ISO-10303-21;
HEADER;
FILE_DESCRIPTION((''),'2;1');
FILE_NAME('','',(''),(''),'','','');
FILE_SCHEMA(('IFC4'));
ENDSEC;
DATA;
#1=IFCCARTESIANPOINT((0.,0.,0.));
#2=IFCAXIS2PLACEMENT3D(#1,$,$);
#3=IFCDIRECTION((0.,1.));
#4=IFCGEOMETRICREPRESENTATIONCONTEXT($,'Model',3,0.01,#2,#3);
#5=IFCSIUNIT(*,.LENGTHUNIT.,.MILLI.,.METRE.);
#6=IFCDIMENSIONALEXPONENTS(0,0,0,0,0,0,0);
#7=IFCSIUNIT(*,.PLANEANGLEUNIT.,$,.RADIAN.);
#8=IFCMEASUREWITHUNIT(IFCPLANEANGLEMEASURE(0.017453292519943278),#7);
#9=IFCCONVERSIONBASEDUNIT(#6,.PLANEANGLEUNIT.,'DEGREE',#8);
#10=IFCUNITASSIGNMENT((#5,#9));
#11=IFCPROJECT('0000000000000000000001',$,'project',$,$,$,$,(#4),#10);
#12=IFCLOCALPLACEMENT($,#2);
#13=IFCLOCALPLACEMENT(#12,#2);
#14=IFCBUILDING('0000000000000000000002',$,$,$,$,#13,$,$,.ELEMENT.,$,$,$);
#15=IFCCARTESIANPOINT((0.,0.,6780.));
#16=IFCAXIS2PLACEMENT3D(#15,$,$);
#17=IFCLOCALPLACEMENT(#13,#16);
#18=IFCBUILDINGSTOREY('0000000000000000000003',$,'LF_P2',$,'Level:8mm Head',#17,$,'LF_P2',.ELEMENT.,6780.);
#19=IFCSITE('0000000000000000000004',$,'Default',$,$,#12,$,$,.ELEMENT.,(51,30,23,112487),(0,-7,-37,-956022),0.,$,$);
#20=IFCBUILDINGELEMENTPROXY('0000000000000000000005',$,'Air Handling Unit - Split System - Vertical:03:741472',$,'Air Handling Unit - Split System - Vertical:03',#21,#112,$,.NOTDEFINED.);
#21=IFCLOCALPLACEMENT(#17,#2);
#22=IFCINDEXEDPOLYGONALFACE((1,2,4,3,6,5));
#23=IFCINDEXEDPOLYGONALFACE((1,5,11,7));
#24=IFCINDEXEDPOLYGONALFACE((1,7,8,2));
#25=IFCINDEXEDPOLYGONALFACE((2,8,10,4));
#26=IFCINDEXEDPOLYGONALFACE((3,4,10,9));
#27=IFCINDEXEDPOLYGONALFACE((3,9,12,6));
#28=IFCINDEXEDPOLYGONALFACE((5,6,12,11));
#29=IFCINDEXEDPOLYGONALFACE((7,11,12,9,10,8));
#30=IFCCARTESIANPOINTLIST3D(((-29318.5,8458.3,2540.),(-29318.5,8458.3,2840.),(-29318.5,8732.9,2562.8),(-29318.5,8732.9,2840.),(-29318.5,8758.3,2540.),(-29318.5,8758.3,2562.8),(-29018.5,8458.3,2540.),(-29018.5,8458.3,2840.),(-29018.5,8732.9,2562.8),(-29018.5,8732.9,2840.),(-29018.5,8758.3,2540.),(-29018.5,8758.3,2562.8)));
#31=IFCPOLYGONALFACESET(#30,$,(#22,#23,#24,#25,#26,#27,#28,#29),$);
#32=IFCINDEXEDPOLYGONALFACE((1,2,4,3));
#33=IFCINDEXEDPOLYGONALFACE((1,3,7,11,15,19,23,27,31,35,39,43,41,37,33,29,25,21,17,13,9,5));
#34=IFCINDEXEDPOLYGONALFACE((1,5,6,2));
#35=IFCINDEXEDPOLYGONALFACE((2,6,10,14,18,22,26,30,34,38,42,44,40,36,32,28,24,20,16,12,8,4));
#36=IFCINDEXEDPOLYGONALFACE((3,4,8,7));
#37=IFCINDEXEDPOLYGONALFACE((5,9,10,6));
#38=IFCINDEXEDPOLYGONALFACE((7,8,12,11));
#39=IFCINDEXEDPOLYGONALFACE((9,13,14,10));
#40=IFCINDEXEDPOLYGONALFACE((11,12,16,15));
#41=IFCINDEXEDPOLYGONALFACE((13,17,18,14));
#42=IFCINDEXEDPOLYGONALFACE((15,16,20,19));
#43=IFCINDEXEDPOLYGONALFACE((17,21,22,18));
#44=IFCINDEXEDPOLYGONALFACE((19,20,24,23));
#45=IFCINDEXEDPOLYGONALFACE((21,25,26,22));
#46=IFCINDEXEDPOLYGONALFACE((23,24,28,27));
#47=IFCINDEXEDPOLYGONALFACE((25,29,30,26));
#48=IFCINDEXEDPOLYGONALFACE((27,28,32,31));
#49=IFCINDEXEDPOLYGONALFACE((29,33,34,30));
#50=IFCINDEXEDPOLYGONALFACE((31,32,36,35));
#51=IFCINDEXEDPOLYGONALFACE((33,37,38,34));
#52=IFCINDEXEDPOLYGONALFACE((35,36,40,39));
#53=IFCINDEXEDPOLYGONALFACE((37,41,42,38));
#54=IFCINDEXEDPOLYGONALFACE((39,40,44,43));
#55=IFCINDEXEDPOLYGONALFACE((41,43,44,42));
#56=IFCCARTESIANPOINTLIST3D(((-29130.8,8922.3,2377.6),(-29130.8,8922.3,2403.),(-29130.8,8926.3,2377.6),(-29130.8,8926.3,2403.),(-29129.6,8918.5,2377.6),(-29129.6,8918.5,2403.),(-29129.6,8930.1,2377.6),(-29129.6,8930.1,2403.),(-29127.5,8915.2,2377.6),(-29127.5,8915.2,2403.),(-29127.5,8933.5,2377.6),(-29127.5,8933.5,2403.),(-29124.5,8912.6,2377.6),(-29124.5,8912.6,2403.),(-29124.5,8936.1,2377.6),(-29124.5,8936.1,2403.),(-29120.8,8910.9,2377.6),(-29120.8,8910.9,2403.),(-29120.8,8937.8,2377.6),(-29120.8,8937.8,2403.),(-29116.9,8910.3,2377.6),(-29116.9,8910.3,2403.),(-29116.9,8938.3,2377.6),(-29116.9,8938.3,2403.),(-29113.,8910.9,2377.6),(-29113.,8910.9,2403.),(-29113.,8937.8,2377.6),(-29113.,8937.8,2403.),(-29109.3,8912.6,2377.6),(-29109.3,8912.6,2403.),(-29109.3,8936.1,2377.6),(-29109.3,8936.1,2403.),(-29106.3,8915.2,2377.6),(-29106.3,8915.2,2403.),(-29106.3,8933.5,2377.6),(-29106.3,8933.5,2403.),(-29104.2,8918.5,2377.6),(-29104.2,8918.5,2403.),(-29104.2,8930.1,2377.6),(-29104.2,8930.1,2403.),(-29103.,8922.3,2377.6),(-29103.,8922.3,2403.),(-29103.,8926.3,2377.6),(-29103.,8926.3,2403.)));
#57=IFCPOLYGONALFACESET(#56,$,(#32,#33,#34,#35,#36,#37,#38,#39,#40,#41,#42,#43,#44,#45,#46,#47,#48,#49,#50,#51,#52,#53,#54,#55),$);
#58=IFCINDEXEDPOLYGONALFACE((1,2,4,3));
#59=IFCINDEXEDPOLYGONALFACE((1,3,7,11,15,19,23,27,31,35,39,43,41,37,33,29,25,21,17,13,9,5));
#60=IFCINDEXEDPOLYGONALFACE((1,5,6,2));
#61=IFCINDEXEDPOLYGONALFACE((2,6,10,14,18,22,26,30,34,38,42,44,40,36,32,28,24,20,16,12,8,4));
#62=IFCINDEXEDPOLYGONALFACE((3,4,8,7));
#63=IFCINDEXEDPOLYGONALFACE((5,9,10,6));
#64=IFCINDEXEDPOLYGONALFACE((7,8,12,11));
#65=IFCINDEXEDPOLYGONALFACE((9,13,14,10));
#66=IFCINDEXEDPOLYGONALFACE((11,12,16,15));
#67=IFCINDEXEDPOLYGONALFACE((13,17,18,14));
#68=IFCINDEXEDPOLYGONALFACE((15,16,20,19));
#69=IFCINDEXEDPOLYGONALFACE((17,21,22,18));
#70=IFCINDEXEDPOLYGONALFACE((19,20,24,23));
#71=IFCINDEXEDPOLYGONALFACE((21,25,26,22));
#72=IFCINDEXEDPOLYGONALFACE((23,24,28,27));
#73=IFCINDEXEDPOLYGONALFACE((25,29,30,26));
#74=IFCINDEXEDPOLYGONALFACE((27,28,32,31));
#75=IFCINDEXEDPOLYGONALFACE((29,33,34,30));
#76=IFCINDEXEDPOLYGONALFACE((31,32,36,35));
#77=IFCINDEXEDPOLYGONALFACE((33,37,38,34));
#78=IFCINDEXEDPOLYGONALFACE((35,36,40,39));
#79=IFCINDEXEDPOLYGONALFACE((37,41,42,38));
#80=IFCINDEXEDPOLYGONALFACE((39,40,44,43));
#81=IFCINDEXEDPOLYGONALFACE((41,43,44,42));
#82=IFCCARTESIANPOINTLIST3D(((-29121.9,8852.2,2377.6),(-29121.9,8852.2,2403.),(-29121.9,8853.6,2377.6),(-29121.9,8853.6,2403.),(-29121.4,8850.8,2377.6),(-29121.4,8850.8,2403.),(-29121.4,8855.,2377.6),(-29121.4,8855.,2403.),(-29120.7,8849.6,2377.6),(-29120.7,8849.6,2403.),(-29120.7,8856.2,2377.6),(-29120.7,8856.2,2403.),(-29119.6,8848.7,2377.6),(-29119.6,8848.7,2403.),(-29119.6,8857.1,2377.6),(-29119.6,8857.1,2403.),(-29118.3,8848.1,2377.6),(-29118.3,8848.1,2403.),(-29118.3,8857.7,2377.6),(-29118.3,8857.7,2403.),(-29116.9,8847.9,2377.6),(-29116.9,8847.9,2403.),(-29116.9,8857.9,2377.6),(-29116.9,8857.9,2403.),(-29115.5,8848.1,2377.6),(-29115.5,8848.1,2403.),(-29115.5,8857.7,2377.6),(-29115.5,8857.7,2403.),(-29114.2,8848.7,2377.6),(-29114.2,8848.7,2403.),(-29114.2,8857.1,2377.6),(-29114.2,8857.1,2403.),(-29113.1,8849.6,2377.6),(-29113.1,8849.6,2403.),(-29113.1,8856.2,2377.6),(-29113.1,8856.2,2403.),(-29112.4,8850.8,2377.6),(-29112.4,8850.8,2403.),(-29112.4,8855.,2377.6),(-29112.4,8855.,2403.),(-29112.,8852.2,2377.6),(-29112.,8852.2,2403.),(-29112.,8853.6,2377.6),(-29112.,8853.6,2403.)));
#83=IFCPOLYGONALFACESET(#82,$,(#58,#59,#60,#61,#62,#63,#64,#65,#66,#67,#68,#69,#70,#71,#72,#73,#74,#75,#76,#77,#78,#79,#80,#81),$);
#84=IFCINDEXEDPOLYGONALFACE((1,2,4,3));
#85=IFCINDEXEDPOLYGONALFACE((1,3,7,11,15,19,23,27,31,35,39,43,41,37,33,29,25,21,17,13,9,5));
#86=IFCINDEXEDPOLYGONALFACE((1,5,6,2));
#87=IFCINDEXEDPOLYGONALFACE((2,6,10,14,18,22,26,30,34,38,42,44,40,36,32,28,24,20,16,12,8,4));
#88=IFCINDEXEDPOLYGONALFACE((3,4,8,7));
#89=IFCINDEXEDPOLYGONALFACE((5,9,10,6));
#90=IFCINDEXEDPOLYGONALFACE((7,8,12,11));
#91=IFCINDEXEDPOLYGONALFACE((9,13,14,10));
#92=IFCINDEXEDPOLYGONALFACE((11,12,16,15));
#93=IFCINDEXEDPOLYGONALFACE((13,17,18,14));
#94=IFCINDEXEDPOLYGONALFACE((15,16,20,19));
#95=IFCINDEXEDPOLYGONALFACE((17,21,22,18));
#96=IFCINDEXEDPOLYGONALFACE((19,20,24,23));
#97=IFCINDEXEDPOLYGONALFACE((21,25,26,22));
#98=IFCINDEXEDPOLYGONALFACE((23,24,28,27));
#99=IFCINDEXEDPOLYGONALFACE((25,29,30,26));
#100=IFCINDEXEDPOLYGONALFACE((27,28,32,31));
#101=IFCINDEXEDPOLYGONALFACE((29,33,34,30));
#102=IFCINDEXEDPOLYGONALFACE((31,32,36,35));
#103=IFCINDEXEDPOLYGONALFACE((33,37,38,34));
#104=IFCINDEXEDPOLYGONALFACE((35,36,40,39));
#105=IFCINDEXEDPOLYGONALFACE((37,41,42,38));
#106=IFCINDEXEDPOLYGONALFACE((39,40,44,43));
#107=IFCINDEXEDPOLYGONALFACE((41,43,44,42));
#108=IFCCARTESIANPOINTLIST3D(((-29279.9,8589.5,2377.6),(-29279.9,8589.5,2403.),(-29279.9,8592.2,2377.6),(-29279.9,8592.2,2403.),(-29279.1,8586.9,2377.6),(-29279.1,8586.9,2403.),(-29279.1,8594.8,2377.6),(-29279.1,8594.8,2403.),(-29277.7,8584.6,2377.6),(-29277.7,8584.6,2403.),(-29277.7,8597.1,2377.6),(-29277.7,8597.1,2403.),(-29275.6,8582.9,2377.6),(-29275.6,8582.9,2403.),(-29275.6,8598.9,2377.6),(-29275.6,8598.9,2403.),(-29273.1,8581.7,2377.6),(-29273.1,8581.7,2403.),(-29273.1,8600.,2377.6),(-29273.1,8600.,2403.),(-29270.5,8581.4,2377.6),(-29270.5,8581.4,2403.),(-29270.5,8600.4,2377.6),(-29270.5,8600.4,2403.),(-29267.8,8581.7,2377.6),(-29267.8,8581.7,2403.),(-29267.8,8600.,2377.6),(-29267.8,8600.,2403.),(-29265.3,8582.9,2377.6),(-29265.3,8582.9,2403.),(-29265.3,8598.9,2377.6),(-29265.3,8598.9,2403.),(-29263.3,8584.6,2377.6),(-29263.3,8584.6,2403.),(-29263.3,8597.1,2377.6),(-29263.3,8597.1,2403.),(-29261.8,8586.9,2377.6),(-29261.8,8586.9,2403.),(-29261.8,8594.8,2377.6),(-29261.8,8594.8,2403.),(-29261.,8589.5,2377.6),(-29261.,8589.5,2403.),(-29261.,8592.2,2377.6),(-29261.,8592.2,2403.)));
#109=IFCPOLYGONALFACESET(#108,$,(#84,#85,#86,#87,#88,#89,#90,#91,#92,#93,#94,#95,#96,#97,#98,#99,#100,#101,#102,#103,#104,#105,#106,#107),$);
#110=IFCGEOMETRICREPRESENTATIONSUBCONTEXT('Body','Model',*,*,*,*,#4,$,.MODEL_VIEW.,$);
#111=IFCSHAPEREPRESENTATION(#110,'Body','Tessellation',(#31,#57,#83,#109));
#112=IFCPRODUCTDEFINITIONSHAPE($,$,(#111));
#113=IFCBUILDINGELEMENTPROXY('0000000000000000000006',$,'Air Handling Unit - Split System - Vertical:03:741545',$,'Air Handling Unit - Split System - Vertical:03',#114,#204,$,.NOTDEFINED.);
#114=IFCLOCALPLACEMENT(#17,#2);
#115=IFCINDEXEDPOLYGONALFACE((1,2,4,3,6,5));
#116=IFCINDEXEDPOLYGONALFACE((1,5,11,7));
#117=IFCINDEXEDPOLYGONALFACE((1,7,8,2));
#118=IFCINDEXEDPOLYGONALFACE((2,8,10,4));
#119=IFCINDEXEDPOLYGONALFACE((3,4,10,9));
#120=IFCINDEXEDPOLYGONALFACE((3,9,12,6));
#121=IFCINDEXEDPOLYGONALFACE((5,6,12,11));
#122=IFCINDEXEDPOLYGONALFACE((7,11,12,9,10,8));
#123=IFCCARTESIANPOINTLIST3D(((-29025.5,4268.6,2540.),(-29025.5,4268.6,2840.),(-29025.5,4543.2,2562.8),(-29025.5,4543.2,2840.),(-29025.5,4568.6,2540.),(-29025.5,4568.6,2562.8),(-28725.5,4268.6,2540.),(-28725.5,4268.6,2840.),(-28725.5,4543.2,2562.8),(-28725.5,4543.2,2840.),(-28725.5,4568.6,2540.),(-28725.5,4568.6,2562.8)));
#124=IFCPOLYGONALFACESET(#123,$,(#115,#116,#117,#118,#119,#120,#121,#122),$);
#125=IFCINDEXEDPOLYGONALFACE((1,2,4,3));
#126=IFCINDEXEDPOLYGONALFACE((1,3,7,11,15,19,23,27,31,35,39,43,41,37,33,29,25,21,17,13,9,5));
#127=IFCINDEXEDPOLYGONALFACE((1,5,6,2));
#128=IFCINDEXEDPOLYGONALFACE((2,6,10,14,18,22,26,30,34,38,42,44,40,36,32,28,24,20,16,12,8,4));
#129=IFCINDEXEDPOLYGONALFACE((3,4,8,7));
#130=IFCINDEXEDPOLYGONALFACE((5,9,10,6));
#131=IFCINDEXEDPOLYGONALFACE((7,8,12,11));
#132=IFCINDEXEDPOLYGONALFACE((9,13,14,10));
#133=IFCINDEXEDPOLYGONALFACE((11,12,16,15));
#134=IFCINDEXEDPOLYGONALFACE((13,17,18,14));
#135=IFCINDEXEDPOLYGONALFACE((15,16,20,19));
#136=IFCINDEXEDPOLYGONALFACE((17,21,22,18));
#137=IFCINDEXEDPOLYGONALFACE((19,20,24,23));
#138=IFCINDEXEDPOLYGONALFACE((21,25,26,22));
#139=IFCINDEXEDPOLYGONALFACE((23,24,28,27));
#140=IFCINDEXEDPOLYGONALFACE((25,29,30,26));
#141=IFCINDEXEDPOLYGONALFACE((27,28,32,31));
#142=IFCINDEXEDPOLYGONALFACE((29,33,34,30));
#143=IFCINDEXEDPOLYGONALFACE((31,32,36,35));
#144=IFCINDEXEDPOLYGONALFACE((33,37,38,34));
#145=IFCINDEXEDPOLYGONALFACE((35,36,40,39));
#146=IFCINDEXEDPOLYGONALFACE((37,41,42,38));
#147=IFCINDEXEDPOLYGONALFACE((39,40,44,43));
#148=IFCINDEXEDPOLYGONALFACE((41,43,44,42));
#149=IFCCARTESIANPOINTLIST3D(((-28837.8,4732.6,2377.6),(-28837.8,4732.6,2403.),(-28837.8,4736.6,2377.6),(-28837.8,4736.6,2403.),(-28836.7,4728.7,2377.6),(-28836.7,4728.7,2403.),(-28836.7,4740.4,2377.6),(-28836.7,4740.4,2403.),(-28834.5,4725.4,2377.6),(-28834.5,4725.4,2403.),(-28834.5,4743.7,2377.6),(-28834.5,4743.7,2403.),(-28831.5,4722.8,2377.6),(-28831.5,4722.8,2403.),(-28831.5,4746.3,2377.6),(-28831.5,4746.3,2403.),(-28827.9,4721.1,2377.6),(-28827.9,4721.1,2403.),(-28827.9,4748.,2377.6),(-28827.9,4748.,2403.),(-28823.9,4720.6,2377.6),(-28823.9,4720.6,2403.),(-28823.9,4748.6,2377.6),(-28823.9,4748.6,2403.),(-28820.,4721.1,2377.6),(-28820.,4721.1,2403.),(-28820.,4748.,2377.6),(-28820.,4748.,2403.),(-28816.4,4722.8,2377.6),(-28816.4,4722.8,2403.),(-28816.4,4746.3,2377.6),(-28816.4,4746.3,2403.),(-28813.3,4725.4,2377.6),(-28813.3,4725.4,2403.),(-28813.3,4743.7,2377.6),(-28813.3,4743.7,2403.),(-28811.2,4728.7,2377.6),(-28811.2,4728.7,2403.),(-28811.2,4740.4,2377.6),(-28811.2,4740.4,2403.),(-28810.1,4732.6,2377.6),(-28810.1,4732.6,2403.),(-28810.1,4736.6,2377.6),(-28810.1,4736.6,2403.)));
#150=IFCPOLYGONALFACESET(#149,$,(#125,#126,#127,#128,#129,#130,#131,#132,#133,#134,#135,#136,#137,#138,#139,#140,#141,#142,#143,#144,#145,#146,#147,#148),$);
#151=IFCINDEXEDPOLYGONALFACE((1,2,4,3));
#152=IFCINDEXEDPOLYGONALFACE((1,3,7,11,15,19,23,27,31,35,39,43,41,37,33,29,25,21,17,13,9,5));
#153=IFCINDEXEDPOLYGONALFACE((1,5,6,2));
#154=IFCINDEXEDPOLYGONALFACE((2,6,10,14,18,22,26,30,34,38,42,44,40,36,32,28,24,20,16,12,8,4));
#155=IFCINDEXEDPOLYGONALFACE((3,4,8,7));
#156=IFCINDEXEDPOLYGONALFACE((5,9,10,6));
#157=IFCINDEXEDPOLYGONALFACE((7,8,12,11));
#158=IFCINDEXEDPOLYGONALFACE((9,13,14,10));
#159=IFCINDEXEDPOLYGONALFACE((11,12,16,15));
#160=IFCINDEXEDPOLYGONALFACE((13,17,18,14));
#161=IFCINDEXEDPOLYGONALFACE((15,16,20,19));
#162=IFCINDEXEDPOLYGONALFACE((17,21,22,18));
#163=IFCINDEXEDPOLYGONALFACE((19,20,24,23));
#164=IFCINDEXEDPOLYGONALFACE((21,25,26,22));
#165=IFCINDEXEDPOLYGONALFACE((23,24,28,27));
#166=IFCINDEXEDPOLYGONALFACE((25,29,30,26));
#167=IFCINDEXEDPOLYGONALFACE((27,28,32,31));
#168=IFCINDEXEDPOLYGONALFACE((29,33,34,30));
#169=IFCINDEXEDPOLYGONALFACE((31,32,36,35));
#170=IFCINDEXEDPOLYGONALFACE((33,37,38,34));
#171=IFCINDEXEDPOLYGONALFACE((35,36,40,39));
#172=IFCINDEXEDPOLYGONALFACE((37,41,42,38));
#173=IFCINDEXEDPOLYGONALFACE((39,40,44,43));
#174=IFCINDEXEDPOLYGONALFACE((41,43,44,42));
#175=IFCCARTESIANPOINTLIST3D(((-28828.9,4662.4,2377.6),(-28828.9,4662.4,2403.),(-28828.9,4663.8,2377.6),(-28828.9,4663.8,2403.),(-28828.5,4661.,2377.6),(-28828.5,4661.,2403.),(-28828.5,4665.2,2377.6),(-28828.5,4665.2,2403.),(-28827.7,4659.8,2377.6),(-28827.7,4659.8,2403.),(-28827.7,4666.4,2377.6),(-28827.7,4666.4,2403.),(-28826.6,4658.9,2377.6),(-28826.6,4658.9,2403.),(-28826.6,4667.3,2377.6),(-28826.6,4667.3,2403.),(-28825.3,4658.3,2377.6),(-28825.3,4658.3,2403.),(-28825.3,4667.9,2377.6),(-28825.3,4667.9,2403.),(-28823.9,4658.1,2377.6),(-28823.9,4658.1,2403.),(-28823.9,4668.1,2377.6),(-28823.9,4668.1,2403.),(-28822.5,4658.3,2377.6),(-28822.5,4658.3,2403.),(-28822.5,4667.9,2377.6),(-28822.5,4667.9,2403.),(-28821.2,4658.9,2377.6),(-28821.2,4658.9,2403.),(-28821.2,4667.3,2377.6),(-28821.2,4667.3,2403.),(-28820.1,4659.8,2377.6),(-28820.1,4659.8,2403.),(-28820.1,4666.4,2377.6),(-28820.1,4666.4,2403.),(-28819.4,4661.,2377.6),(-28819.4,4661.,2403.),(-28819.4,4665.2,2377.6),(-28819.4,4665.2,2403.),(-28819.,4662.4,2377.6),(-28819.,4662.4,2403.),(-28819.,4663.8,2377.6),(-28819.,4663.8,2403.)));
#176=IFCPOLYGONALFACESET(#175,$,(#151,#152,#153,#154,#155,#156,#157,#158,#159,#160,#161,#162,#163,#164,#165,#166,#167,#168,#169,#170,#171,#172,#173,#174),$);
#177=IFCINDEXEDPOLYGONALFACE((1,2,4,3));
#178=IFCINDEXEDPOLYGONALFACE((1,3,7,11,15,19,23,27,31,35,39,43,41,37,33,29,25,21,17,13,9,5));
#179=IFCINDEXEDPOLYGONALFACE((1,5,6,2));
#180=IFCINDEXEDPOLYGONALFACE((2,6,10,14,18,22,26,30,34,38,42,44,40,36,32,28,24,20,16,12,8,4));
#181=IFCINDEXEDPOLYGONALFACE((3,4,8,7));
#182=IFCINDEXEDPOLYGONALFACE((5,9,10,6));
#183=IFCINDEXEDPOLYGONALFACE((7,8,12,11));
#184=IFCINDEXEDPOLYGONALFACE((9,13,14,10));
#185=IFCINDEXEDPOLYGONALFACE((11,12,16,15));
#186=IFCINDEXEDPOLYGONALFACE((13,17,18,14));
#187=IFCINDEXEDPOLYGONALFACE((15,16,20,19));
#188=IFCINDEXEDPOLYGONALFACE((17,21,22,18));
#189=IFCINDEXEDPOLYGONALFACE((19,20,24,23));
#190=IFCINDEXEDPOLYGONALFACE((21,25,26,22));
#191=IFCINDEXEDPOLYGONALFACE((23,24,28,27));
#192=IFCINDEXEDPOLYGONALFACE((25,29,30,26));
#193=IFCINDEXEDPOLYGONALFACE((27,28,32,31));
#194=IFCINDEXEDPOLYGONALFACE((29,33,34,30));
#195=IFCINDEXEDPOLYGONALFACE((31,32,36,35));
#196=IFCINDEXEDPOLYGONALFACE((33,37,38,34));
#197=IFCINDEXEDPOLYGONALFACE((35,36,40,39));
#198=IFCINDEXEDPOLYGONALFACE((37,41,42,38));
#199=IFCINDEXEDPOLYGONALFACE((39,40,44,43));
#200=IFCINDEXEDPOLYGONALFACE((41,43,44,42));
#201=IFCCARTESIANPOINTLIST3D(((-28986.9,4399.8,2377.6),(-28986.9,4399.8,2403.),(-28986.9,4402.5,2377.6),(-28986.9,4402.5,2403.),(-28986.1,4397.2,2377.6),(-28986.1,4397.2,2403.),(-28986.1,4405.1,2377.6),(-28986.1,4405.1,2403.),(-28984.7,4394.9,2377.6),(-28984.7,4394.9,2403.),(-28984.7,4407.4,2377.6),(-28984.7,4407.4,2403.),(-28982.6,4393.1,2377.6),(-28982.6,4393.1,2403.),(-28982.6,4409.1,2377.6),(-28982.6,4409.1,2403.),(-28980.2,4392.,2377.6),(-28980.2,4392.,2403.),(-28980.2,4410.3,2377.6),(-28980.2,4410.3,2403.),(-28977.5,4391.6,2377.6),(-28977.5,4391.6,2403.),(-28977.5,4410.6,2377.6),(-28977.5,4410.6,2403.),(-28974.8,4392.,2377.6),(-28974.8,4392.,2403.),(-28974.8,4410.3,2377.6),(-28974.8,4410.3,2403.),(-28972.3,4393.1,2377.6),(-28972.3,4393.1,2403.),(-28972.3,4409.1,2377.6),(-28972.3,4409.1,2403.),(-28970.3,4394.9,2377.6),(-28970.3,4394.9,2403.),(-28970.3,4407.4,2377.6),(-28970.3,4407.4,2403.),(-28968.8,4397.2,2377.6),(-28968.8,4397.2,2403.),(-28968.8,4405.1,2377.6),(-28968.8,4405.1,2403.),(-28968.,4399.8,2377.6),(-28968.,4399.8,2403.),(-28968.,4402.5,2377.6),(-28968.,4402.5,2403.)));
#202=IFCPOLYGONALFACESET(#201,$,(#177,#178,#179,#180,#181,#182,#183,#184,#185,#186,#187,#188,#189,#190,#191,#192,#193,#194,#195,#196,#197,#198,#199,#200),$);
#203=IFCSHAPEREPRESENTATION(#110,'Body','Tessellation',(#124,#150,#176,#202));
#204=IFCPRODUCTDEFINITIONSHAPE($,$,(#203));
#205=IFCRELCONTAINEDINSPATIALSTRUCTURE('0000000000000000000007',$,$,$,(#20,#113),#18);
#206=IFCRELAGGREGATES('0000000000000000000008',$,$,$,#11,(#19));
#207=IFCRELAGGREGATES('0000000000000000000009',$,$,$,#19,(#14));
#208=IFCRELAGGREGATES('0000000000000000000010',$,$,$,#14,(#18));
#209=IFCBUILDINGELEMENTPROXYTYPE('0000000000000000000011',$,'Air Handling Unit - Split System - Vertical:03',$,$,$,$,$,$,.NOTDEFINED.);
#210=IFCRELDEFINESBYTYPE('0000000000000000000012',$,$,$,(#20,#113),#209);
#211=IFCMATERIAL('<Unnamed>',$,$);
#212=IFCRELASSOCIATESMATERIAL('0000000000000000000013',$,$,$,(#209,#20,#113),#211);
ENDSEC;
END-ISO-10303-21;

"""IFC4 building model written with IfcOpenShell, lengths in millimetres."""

from ifc_helpers import new_model, entity, si_unit, converted_unit, direction, frame, origin, place, context, subcontext, project, spatial, arc, indexed_curve, outline, extrude, source, transform, mapped, material, type_object, type_shapes, element, save


model = new_model("IFC4")

# Units and contexts
model_context = context("Model", 3, precision=0.01, world=origin(), true_north=direction((0.0, 1.0)))
body_context = subcontext(model_context, "Body", "Model", "MODEL_VIEW")
ifc_project = project(units=[si_unit("LENGTHUNIT", "METRE", prefix="MILLI"), converted_unit("PLANEANGLEUNIT", "DEGREE", entity("IfcPlaneAngleMeasure", 0.017453292519943278), si_unit("PLANEANGLEUNIT", "RADIAN"), dimensions=[0, 0, 0, 0, 0, 0, 0])], contexts=[model_context])

# Site, building, storey
site_placement = place(None, origin())
site = spatial("IfcSite", under=ifc_project, at=site_placement, Name="Default", CompositionType="ELEMENT", RefLatitude=(51, 30, 23, 112487), RefLongitude=(0, -7, -37, -956022), RefElevation=0.0)
building_placement = place(site_placement, origin())
building = spatial("IfcBuilding", under=site, at=building_placement, CompositionType="ELEMENT")
storey_placement = place(building_placement, frame((0.0, 0.0, 6780.0)))
storey = spatial("IfcBuildingStorey", under=building, at=storey_placement, Name="LF_P2", ObjectType="Level:8mm Head", LongName="LF_P2", CompositionType="ELEMENT", Elevation=6780.0)

# Shared definitions
ifc_material = material(Name="<Unnamed>")

# Building element proxies
building_element_proxy_type_1 = type_object("IfcBuildingElementProxyType", Name="Air Handling Unit - Split System - Vertical:03", PredefinedType="NOTDEFINED", material=ifc_material)
shared_shape_1 = source(origin(), body_context, "Body", "SweptSolid", [
    extrude(outline(indexed_curve([(-191.5, -107.6), (108.5, -107.6), (108.5, -84.8), (83.1, -84.8), (83.1, 192.4), (-191.5, 192.4), (-191.5, -107.6)], self_intersect=False)), frame((-150.0, 42.4, 191.5), z_axis=(1.0, 0.0, 0.0), x_axis=(0.0, 0.0, 1.0)), (0.0, 0.0, 1.0), 300.0),
    extrude(outline(indexed_curve([(-14.0, 0.0), (0.0, -14.0), (14.0, 0.0), (0.0, 14.0)], segments=[arc(1, 2, 3), arc(3, 4, 1)], self_intersect=False)), frame((51.6, 287.0, 466.0), z_axis=(0.0, 1.0, 0.0), x_axis=(0.0, 0.0, -1.0)), (0.0, 0.0, 1.0), 25.4),
    extrude(outline(indexed_curve([(-5.0, 0.0), (0.0, -5.0), (5.0, 0.0), (0.0, 5.0)], segments=[arc(1, 2, 3), arc(3, 4, 1)], self_intersect=False)), frame((51.6, 287.0, 394.6), z_axis=(0.0, 1.0, 0.0), x_axis=(0.0, 0.0, -1.0)), (0.0, 0.0, 1.0), 25.4),
    extrude(outline(indexed_curve([(-9.5, 0.0), (0.0, -9.5), (9.5, 0.0), (0.0, 9.5)], segments=[arc(1, 2, 3), arc(3, 4, 1)], self_intersect=False)), frame((-102.0, 287.0, 132.6), z_axis=(0.0, 1.0, 0.0), x_axis=(0.0, 0.0, -1.0)), (0.0, 0.0, 1.0), 25.4),
])
type_shapes(building_element_proxy_type_1, [shared_shape_1])
for number, where, z_axis, x_axis, name in (
    (1, (-29168.5, 8458.3, 2690.0), (0.0, 1.0, 0.0), (1.0, 0.0, 0.0), "Air Handling Unit - Split System - Vertical:03:741472"),
    (2, (-28875.5, 4268.6, 2690.0), (0.0, 1.0, 0.0), (1.0, 0.0, 0.0), "Air Handling Unit - Split System - Vertical:03:741545"),
):
    element("IfcBuildingElementProxy", number, at=place(storey_placement, frame(where, z_axis=z_axis, x_axis=x_axis)), inside=storey, type_object=building_element_proxy_type_1, material=ifc_material, Name=name, ObjectType="Air Handling Unit - Split System - Vertical:03", PredefinedType="NOTDEFINED", context=body_context, shape_type="MappedRepresentation", body=[
        mapped(shared_shape_1, transform((0.0, 0.0, 0.0), scale=1.0)),
    ])

save(model, "model.ifc")
